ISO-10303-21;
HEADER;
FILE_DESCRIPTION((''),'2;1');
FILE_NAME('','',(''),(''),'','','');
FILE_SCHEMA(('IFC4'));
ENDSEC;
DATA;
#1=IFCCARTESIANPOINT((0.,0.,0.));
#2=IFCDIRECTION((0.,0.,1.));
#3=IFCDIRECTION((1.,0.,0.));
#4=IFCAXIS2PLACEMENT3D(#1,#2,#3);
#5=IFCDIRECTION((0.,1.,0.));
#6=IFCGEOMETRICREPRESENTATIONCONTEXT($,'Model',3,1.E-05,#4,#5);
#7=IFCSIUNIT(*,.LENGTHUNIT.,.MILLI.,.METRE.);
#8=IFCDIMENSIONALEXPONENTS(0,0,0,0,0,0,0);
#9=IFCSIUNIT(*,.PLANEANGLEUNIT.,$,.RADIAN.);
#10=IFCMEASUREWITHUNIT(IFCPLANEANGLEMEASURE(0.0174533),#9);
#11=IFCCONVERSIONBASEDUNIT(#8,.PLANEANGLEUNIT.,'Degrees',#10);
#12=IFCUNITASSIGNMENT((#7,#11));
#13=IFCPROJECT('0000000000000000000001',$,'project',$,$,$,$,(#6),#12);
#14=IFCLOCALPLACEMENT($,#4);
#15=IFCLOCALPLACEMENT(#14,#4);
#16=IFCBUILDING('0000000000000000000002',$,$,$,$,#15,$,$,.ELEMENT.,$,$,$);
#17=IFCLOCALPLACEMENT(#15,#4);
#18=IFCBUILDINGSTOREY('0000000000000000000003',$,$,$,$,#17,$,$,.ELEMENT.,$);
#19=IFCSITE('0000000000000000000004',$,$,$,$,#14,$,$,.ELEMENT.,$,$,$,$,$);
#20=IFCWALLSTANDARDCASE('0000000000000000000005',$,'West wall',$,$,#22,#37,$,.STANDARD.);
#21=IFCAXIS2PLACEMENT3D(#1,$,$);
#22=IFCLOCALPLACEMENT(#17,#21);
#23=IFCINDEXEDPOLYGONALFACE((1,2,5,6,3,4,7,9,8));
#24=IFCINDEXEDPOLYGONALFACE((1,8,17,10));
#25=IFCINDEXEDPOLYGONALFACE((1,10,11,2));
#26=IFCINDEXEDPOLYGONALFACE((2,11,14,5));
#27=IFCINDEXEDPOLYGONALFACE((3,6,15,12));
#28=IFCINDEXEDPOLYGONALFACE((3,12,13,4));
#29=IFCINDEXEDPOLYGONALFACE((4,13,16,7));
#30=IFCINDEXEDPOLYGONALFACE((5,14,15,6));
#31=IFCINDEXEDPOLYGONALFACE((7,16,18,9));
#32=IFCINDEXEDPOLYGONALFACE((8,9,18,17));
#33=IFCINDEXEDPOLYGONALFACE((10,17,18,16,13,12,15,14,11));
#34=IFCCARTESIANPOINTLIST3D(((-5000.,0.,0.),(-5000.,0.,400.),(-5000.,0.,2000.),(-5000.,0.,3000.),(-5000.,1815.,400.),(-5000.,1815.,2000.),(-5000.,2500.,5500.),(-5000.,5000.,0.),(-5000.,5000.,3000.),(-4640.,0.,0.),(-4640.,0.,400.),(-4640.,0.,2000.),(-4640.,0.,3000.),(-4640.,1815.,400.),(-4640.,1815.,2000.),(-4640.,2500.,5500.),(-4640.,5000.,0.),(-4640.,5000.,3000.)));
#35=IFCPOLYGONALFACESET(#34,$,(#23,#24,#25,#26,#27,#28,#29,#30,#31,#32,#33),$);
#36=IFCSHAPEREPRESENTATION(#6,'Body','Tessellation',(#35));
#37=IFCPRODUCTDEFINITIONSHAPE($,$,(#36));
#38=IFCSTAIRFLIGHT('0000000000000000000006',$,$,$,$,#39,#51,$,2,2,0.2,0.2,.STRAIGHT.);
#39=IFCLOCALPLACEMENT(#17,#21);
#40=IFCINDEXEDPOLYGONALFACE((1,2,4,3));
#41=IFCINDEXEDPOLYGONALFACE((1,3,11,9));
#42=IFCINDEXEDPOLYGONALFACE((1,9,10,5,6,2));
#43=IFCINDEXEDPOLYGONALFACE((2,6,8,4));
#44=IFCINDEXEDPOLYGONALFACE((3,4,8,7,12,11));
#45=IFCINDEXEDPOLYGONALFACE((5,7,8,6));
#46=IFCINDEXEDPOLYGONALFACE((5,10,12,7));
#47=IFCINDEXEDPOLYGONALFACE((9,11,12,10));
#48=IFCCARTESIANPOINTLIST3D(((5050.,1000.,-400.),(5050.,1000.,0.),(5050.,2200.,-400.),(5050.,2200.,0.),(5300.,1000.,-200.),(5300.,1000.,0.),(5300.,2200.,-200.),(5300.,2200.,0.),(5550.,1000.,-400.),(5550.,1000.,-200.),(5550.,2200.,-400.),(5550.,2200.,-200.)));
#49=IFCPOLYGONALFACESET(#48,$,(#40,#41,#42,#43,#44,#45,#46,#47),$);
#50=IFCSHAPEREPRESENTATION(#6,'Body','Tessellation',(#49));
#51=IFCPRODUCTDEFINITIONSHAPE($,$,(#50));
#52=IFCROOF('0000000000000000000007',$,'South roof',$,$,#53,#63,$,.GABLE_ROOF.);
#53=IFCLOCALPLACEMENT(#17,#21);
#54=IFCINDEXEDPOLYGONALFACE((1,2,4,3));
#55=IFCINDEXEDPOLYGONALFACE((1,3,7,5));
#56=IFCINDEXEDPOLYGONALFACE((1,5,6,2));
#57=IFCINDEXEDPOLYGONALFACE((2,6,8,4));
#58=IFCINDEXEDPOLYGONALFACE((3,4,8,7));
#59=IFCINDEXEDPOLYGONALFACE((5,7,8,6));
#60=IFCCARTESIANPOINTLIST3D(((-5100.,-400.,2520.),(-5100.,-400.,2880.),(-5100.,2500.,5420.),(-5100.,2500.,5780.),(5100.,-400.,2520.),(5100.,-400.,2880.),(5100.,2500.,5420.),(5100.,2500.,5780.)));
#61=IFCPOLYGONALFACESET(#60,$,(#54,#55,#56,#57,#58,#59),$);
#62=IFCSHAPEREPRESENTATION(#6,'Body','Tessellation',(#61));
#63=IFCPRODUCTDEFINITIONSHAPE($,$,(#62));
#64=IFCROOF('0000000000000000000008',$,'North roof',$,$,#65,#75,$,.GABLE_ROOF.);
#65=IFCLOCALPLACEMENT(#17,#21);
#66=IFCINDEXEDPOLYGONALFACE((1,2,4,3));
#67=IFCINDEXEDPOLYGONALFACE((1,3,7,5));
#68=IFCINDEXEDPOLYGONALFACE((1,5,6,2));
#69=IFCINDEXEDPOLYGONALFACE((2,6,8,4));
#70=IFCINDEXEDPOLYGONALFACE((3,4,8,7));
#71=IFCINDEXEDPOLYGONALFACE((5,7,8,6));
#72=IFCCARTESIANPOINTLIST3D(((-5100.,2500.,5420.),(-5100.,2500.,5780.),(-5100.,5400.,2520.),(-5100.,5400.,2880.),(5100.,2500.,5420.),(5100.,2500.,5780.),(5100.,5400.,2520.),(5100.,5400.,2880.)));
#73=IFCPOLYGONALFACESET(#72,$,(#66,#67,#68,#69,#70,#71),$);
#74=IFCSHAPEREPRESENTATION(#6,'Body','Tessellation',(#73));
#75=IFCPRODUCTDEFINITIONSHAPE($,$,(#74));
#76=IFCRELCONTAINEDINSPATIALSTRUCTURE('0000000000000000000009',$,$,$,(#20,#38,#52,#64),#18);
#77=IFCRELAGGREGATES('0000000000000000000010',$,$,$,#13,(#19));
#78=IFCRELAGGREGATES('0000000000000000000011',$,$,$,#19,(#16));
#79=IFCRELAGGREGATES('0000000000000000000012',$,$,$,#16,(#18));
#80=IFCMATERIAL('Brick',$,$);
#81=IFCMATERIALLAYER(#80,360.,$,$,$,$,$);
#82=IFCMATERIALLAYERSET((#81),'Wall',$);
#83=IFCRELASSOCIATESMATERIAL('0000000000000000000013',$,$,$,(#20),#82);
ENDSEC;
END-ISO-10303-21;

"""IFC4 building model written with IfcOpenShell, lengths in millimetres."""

from ifc_helpers import new_model, entity, si_unit, converted_unit, direction, frame, origin_with_axes, place, context, project, spatial, polyline, outline, extrude, clip, halfspace, material, layer, layer_set, layer_usage, element, save


model = new_model("IFC4")

# Units and contexts
model_context = context("Model", 3, precision=1e-05, world=origin_with_axes(), true_north=direction((0.0, 1.0, 0.0)))
ifc_project = project(units=[si_unit("LENGTHUNIT", "METRE", prefix="MILLI"), converted_unit("PLANEANGLEUNIT", "Degrees", entity("IfcPlaneAngleMeasure", 0.0174533), si_unit("PLANEANGLEUNIT", "RADIAN"), dimensions=[0, 0, 0, 0, 0, 0, 0])], contexts=[model_context])

# Site, building, storey
site_placement = place(None, origin_with_axes())
site = spatial("IfcSite", under=ifc_project, at=site_placement, CompositionType="ELEMENT")
building_placement = place(site_placement, origin_with_axes())
building = spatial("IfcBuilding", under=site, at=building_placement, CompositionType="ELEMENT")
storey_placement = place(building_placement, origin_with_axes())
storey = spatial("IfcBuildingStorey", under=building, at=storey_placement, CompositionType="ELEMENT")

# Shared definitions
ifc_material = material(Name="Brick")
ifc_layer = layer(ifc_material, 360.0)
ifc_layer_set = layer_set([ifc_layer], Name="Wall")
ifc_layer_usage = layer_usage(ifc_layer_set, "AXIS2", "POSITIVE", -180.0)
placement = place(None, frame((-2500.0, 0.0, 400.0), z_axis=(0.0, 0.0, 1.0), x_axis=(1.0, 0.0, 0.0)))

# Wall, opening
wall_1_placement = place(storey_placement, frame((-4820.0, 2500.0, 0.0), z_axis=(0.0, 0.0, 1.0), x_axis=(0.0, -1.0, 0.0)))
wall_1 = element("IfcWallStandardCase", 1, at=wall_1_placement, inside=storey, material=ifc_layer_usage, Name="West wall", PredefinedType="STANDARD", context=model_context, shape_type="Clipping", body=[
    clip(clip(extrude(outline(polyline([(-2500.0, -180.0), (2500.0, -180.0), (2500.0, 180.0), (-2500.0, 180.0), (-2500.0, -180.0), (-2500.0, -180.0)])), origin_with_axes(), (0.0, 0.0, 1.0), 6000.0), halfspace(frame((-2500.0, 0.0, 3000.0), z_axis=(-1.0, 0.0, 1.0), x_axis=(1.0, 0.0, 0.0)), False)), halfspace(frame((2500.0, 0.0, 3000.0), z_axis=(1.0, 0.0, 1.0), x_axis=(1.0, 0.0, 0.0)), False)),
])
element("IfcOpeningElement", 2, at=placement, cuts=wall_1, PredefinedType="OPENING", context=model_context, shape_type="SweptSolid", body=[
    extrude(outline(polyline([(-3000.0, -1815.0), (3000.0, -1815.0), (3000.0, 1815.0), (-3000.0, 1815.0), (-3000.0, -1815.0), (-3000.0, -1815.0)])), origin_with_axes(), (0.0, 0.0, 1.0), 1600.0),
])

# Stair flight
stair_flight_placement = place(storey_placement, frame((5050.0, 1000.0, 0.0), z_axis=(0.0, 1.0, 0.0), x_axis=(1.0, 0.0, 0.0)))
element("IfcStairFlight", 3, at=stair_flight_placement, inside=storey, NumberOfRisers=2, NumberOfTreads=2, PredefinedType="STRAIGHT", RiserHeight=0.2, TreadLength=0.2, context=model_context, shape_type="SweptSolid", body=[
    extrude(outline(polyline([(0.0, 0.0), (250.0, 0.0), (250.0, 200.0), (500.0, 200.0), (500.0, 400.0), (0.0, 400.0), (0.0, 0.0)])), origin_with_axes(), (0.0, 0.0, 1.0), 1200.0),
])

# Roofs
for number, where, z_axis, x_axis, name in (
    (4, (0.0, -400.0, 2700.0), (0.0, 0.0, 1.0), (1.0, 0.0, 0.0), "South roof"),
    (5, (0.0, 5400.0, 2700.0), (0.0, 0.0, 1.0), (-1.0, 0.0, 0.0), "North roof"),
):
    element("IfcRoof", number, at=place(storey_placement, frame(where, z_axis=z_axis, x_axis=x_axis)), inside=storey, Name=name, PredefinedType="GABLE_ROOF", context=model_context, shape_type="SweptSolid", body=[
        extrude(outline(polyline([(-5100.0, -180.0), (5100.0, -180.0), (5100.0, 180.0), (-5100.0, 180.0), (-5100.0, -180.0), (-5100.0, -180.0)])), frame((0.0, 0.0, 0.0), z_axis=(0.0, 1.0, 0.0), x_axis=(1.0, 0.0, 0.0)), (0.0, -0.707107, 0.707107), 4101.2),
    ])

save(model, "model.ifc")
